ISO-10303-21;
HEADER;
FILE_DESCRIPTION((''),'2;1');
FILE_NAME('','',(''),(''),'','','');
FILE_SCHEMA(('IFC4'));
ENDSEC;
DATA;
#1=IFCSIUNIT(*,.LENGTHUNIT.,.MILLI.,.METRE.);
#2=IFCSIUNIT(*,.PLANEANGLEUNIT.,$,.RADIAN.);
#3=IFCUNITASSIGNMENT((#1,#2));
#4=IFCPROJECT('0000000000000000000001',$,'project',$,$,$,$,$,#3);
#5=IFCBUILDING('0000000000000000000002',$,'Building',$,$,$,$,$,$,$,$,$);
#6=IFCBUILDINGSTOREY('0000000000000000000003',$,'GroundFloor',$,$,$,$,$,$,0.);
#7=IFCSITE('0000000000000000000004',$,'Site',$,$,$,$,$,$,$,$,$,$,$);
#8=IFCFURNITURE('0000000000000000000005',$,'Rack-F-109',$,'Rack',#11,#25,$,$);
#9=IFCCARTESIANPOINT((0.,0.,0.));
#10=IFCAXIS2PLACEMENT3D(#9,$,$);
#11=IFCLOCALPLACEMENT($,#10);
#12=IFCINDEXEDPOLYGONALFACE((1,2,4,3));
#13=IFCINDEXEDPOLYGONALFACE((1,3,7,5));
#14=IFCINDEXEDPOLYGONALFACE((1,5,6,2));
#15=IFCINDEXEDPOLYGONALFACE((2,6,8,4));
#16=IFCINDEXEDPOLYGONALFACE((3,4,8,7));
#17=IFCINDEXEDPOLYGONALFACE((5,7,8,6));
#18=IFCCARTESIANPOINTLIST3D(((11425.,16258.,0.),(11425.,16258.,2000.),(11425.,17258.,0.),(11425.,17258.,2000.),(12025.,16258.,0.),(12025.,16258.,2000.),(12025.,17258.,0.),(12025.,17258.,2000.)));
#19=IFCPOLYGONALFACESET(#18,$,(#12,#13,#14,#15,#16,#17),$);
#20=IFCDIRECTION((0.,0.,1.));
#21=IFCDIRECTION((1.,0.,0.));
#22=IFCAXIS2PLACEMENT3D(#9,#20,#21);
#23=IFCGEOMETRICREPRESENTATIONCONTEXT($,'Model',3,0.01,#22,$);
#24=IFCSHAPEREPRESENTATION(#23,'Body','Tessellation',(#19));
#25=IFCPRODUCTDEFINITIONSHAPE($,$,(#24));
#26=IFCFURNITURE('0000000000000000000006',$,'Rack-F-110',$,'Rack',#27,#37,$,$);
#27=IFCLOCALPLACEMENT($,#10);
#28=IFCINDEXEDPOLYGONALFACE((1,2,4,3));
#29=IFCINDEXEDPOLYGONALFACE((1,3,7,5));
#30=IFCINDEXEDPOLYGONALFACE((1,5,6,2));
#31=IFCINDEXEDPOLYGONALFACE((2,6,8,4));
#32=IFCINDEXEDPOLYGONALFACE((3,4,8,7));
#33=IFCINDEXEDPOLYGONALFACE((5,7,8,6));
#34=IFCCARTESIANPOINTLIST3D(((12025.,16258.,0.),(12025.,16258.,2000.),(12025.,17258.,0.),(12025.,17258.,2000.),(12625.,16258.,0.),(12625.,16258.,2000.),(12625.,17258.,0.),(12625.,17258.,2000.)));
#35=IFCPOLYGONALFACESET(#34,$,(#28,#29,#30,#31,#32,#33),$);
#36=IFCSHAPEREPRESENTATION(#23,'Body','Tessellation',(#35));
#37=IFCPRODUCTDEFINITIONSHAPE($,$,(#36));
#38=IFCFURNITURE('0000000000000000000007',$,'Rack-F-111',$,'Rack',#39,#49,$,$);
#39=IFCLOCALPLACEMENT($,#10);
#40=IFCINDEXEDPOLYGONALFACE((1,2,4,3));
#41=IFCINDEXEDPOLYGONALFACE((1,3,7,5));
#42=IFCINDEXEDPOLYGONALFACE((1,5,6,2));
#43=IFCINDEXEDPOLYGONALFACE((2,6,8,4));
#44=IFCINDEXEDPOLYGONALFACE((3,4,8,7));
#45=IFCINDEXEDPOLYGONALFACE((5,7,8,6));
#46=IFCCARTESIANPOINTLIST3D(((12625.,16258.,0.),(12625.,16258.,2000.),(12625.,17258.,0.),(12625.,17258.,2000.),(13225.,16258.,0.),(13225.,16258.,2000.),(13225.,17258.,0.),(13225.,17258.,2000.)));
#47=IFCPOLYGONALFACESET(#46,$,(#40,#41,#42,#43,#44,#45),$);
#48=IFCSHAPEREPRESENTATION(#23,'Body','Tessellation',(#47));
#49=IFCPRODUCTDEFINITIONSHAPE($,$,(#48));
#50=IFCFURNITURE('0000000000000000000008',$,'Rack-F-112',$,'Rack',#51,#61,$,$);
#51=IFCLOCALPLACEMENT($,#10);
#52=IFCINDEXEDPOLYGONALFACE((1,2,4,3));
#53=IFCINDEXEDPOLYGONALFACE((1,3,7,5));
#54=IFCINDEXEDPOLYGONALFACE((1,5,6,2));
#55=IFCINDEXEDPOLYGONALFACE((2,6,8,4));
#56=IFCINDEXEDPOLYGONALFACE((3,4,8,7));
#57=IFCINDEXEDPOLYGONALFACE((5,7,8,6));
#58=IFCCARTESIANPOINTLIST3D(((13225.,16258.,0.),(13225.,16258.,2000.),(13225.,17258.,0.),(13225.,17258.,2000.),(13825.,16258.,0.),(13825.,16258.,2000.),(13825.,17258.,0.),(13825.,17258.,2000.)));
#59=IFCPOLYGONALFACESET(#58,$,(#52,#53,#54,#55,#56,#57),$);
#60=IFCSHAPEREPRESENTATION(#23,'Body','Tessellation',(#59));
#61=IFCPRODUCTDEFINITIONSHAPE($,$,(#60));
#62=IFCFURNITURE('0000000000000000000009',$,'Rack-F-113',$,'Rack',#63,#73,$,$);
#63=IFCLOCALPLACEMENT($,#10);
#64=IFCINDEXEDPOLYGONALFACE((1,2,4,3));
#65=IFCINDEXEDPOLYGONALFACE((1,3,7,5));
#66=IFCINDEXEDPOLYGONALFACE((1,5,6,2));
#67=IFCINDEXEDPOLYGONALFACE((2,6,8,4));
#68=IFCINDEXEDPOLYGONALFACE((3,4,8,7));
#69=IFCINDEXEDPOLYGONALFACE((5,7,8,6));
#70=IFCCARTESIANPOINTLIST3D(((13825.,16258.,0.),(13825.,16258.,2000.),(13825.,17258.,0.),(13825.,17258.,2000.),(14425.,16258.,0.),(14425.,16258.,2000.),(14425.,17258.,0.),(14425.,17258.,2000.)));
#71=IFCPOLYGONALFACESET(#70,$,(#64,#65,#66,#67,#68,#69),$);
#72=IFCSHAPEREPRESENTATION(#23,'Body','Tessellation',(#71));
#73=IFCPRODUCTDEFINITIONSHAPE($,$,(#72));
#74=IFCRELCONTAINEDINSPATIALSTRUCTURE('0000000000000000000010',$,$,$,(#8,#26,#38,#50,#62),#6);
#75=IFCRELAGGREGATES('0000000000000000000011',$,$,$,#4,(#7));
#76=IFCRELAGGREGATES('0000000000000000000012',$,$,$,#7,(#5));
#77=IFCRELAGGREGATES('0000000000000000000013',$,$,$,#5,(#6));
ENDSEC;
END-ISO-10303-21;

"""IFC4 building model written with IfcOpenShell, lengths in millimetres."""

from ifc_helpers import new_model, si_unit, frame, origin, origin_with_axes, origin_2d, place, context, project, spatial, rectangle, extrude, element, save


model = new_model("IFC4")

# Units and contexts
model_context = context("Model", 3, precision=0.01, world=origin_with_axes())
ifc_project = project(units=[si_unit("LENGTHUNIT", "METRE", prefix="MILLI"), si_unit("PLANEANGLEUNIT", "RADIAN")])

# Site, building, storey
site = spatial("IfcSite", under=ifc_project, Name="Site")
building = spatial("IfcBuilding", under=site, Name="Building")
storey = spatial("IfcBuildingStorey", under=building, Name="GroundFloor", Elevation=0.0)

# Furniture
for number, where, z_axis, x_axis, name in (
    (1, (11725.0, 16758.0, 0.0), (0.0, 0.0, 1.0), (1.0, 0.0, 0.0), "Rack-F-109"),
    (2, (12325.0, 16758.0, 0.0), (0.0, 0.0, 1.0), (1.0, 0.0, 0.0), "Rack-F-110"),
    (3, (12925.0, 16758.0, 0.0), (0.0, 0.0, 1.0), (1.0, 0.0, 0.0), "Rack-F-111"),
    (4, (13525.0, 16758.0, 0.0), (0.0, 0.0, 1.0), (1.0, 0.0, 0.0), "Rack-F-112"),
    (5, (14125.0, 16758.0, 0.0), (0.0, 0.0, 1.0), (1.0, 0.0, 0.0), "Rack-F-113"),
):
    element("IfcFurniture", number, at=place(None, frame(where, z_axis=z_axis, x_axis=x_axis)), inside=storey, Name=name, ObjectType="Rack", context=model_context, shape_type="SweptSolid", body=[
        extrude(rectangle(XDim=600.0, YDim=1000.0, at=origin_2d()), origin(), (0.0, 0.0, 1.0), 2000.0),
    ])

save(model, "model.ifc")
